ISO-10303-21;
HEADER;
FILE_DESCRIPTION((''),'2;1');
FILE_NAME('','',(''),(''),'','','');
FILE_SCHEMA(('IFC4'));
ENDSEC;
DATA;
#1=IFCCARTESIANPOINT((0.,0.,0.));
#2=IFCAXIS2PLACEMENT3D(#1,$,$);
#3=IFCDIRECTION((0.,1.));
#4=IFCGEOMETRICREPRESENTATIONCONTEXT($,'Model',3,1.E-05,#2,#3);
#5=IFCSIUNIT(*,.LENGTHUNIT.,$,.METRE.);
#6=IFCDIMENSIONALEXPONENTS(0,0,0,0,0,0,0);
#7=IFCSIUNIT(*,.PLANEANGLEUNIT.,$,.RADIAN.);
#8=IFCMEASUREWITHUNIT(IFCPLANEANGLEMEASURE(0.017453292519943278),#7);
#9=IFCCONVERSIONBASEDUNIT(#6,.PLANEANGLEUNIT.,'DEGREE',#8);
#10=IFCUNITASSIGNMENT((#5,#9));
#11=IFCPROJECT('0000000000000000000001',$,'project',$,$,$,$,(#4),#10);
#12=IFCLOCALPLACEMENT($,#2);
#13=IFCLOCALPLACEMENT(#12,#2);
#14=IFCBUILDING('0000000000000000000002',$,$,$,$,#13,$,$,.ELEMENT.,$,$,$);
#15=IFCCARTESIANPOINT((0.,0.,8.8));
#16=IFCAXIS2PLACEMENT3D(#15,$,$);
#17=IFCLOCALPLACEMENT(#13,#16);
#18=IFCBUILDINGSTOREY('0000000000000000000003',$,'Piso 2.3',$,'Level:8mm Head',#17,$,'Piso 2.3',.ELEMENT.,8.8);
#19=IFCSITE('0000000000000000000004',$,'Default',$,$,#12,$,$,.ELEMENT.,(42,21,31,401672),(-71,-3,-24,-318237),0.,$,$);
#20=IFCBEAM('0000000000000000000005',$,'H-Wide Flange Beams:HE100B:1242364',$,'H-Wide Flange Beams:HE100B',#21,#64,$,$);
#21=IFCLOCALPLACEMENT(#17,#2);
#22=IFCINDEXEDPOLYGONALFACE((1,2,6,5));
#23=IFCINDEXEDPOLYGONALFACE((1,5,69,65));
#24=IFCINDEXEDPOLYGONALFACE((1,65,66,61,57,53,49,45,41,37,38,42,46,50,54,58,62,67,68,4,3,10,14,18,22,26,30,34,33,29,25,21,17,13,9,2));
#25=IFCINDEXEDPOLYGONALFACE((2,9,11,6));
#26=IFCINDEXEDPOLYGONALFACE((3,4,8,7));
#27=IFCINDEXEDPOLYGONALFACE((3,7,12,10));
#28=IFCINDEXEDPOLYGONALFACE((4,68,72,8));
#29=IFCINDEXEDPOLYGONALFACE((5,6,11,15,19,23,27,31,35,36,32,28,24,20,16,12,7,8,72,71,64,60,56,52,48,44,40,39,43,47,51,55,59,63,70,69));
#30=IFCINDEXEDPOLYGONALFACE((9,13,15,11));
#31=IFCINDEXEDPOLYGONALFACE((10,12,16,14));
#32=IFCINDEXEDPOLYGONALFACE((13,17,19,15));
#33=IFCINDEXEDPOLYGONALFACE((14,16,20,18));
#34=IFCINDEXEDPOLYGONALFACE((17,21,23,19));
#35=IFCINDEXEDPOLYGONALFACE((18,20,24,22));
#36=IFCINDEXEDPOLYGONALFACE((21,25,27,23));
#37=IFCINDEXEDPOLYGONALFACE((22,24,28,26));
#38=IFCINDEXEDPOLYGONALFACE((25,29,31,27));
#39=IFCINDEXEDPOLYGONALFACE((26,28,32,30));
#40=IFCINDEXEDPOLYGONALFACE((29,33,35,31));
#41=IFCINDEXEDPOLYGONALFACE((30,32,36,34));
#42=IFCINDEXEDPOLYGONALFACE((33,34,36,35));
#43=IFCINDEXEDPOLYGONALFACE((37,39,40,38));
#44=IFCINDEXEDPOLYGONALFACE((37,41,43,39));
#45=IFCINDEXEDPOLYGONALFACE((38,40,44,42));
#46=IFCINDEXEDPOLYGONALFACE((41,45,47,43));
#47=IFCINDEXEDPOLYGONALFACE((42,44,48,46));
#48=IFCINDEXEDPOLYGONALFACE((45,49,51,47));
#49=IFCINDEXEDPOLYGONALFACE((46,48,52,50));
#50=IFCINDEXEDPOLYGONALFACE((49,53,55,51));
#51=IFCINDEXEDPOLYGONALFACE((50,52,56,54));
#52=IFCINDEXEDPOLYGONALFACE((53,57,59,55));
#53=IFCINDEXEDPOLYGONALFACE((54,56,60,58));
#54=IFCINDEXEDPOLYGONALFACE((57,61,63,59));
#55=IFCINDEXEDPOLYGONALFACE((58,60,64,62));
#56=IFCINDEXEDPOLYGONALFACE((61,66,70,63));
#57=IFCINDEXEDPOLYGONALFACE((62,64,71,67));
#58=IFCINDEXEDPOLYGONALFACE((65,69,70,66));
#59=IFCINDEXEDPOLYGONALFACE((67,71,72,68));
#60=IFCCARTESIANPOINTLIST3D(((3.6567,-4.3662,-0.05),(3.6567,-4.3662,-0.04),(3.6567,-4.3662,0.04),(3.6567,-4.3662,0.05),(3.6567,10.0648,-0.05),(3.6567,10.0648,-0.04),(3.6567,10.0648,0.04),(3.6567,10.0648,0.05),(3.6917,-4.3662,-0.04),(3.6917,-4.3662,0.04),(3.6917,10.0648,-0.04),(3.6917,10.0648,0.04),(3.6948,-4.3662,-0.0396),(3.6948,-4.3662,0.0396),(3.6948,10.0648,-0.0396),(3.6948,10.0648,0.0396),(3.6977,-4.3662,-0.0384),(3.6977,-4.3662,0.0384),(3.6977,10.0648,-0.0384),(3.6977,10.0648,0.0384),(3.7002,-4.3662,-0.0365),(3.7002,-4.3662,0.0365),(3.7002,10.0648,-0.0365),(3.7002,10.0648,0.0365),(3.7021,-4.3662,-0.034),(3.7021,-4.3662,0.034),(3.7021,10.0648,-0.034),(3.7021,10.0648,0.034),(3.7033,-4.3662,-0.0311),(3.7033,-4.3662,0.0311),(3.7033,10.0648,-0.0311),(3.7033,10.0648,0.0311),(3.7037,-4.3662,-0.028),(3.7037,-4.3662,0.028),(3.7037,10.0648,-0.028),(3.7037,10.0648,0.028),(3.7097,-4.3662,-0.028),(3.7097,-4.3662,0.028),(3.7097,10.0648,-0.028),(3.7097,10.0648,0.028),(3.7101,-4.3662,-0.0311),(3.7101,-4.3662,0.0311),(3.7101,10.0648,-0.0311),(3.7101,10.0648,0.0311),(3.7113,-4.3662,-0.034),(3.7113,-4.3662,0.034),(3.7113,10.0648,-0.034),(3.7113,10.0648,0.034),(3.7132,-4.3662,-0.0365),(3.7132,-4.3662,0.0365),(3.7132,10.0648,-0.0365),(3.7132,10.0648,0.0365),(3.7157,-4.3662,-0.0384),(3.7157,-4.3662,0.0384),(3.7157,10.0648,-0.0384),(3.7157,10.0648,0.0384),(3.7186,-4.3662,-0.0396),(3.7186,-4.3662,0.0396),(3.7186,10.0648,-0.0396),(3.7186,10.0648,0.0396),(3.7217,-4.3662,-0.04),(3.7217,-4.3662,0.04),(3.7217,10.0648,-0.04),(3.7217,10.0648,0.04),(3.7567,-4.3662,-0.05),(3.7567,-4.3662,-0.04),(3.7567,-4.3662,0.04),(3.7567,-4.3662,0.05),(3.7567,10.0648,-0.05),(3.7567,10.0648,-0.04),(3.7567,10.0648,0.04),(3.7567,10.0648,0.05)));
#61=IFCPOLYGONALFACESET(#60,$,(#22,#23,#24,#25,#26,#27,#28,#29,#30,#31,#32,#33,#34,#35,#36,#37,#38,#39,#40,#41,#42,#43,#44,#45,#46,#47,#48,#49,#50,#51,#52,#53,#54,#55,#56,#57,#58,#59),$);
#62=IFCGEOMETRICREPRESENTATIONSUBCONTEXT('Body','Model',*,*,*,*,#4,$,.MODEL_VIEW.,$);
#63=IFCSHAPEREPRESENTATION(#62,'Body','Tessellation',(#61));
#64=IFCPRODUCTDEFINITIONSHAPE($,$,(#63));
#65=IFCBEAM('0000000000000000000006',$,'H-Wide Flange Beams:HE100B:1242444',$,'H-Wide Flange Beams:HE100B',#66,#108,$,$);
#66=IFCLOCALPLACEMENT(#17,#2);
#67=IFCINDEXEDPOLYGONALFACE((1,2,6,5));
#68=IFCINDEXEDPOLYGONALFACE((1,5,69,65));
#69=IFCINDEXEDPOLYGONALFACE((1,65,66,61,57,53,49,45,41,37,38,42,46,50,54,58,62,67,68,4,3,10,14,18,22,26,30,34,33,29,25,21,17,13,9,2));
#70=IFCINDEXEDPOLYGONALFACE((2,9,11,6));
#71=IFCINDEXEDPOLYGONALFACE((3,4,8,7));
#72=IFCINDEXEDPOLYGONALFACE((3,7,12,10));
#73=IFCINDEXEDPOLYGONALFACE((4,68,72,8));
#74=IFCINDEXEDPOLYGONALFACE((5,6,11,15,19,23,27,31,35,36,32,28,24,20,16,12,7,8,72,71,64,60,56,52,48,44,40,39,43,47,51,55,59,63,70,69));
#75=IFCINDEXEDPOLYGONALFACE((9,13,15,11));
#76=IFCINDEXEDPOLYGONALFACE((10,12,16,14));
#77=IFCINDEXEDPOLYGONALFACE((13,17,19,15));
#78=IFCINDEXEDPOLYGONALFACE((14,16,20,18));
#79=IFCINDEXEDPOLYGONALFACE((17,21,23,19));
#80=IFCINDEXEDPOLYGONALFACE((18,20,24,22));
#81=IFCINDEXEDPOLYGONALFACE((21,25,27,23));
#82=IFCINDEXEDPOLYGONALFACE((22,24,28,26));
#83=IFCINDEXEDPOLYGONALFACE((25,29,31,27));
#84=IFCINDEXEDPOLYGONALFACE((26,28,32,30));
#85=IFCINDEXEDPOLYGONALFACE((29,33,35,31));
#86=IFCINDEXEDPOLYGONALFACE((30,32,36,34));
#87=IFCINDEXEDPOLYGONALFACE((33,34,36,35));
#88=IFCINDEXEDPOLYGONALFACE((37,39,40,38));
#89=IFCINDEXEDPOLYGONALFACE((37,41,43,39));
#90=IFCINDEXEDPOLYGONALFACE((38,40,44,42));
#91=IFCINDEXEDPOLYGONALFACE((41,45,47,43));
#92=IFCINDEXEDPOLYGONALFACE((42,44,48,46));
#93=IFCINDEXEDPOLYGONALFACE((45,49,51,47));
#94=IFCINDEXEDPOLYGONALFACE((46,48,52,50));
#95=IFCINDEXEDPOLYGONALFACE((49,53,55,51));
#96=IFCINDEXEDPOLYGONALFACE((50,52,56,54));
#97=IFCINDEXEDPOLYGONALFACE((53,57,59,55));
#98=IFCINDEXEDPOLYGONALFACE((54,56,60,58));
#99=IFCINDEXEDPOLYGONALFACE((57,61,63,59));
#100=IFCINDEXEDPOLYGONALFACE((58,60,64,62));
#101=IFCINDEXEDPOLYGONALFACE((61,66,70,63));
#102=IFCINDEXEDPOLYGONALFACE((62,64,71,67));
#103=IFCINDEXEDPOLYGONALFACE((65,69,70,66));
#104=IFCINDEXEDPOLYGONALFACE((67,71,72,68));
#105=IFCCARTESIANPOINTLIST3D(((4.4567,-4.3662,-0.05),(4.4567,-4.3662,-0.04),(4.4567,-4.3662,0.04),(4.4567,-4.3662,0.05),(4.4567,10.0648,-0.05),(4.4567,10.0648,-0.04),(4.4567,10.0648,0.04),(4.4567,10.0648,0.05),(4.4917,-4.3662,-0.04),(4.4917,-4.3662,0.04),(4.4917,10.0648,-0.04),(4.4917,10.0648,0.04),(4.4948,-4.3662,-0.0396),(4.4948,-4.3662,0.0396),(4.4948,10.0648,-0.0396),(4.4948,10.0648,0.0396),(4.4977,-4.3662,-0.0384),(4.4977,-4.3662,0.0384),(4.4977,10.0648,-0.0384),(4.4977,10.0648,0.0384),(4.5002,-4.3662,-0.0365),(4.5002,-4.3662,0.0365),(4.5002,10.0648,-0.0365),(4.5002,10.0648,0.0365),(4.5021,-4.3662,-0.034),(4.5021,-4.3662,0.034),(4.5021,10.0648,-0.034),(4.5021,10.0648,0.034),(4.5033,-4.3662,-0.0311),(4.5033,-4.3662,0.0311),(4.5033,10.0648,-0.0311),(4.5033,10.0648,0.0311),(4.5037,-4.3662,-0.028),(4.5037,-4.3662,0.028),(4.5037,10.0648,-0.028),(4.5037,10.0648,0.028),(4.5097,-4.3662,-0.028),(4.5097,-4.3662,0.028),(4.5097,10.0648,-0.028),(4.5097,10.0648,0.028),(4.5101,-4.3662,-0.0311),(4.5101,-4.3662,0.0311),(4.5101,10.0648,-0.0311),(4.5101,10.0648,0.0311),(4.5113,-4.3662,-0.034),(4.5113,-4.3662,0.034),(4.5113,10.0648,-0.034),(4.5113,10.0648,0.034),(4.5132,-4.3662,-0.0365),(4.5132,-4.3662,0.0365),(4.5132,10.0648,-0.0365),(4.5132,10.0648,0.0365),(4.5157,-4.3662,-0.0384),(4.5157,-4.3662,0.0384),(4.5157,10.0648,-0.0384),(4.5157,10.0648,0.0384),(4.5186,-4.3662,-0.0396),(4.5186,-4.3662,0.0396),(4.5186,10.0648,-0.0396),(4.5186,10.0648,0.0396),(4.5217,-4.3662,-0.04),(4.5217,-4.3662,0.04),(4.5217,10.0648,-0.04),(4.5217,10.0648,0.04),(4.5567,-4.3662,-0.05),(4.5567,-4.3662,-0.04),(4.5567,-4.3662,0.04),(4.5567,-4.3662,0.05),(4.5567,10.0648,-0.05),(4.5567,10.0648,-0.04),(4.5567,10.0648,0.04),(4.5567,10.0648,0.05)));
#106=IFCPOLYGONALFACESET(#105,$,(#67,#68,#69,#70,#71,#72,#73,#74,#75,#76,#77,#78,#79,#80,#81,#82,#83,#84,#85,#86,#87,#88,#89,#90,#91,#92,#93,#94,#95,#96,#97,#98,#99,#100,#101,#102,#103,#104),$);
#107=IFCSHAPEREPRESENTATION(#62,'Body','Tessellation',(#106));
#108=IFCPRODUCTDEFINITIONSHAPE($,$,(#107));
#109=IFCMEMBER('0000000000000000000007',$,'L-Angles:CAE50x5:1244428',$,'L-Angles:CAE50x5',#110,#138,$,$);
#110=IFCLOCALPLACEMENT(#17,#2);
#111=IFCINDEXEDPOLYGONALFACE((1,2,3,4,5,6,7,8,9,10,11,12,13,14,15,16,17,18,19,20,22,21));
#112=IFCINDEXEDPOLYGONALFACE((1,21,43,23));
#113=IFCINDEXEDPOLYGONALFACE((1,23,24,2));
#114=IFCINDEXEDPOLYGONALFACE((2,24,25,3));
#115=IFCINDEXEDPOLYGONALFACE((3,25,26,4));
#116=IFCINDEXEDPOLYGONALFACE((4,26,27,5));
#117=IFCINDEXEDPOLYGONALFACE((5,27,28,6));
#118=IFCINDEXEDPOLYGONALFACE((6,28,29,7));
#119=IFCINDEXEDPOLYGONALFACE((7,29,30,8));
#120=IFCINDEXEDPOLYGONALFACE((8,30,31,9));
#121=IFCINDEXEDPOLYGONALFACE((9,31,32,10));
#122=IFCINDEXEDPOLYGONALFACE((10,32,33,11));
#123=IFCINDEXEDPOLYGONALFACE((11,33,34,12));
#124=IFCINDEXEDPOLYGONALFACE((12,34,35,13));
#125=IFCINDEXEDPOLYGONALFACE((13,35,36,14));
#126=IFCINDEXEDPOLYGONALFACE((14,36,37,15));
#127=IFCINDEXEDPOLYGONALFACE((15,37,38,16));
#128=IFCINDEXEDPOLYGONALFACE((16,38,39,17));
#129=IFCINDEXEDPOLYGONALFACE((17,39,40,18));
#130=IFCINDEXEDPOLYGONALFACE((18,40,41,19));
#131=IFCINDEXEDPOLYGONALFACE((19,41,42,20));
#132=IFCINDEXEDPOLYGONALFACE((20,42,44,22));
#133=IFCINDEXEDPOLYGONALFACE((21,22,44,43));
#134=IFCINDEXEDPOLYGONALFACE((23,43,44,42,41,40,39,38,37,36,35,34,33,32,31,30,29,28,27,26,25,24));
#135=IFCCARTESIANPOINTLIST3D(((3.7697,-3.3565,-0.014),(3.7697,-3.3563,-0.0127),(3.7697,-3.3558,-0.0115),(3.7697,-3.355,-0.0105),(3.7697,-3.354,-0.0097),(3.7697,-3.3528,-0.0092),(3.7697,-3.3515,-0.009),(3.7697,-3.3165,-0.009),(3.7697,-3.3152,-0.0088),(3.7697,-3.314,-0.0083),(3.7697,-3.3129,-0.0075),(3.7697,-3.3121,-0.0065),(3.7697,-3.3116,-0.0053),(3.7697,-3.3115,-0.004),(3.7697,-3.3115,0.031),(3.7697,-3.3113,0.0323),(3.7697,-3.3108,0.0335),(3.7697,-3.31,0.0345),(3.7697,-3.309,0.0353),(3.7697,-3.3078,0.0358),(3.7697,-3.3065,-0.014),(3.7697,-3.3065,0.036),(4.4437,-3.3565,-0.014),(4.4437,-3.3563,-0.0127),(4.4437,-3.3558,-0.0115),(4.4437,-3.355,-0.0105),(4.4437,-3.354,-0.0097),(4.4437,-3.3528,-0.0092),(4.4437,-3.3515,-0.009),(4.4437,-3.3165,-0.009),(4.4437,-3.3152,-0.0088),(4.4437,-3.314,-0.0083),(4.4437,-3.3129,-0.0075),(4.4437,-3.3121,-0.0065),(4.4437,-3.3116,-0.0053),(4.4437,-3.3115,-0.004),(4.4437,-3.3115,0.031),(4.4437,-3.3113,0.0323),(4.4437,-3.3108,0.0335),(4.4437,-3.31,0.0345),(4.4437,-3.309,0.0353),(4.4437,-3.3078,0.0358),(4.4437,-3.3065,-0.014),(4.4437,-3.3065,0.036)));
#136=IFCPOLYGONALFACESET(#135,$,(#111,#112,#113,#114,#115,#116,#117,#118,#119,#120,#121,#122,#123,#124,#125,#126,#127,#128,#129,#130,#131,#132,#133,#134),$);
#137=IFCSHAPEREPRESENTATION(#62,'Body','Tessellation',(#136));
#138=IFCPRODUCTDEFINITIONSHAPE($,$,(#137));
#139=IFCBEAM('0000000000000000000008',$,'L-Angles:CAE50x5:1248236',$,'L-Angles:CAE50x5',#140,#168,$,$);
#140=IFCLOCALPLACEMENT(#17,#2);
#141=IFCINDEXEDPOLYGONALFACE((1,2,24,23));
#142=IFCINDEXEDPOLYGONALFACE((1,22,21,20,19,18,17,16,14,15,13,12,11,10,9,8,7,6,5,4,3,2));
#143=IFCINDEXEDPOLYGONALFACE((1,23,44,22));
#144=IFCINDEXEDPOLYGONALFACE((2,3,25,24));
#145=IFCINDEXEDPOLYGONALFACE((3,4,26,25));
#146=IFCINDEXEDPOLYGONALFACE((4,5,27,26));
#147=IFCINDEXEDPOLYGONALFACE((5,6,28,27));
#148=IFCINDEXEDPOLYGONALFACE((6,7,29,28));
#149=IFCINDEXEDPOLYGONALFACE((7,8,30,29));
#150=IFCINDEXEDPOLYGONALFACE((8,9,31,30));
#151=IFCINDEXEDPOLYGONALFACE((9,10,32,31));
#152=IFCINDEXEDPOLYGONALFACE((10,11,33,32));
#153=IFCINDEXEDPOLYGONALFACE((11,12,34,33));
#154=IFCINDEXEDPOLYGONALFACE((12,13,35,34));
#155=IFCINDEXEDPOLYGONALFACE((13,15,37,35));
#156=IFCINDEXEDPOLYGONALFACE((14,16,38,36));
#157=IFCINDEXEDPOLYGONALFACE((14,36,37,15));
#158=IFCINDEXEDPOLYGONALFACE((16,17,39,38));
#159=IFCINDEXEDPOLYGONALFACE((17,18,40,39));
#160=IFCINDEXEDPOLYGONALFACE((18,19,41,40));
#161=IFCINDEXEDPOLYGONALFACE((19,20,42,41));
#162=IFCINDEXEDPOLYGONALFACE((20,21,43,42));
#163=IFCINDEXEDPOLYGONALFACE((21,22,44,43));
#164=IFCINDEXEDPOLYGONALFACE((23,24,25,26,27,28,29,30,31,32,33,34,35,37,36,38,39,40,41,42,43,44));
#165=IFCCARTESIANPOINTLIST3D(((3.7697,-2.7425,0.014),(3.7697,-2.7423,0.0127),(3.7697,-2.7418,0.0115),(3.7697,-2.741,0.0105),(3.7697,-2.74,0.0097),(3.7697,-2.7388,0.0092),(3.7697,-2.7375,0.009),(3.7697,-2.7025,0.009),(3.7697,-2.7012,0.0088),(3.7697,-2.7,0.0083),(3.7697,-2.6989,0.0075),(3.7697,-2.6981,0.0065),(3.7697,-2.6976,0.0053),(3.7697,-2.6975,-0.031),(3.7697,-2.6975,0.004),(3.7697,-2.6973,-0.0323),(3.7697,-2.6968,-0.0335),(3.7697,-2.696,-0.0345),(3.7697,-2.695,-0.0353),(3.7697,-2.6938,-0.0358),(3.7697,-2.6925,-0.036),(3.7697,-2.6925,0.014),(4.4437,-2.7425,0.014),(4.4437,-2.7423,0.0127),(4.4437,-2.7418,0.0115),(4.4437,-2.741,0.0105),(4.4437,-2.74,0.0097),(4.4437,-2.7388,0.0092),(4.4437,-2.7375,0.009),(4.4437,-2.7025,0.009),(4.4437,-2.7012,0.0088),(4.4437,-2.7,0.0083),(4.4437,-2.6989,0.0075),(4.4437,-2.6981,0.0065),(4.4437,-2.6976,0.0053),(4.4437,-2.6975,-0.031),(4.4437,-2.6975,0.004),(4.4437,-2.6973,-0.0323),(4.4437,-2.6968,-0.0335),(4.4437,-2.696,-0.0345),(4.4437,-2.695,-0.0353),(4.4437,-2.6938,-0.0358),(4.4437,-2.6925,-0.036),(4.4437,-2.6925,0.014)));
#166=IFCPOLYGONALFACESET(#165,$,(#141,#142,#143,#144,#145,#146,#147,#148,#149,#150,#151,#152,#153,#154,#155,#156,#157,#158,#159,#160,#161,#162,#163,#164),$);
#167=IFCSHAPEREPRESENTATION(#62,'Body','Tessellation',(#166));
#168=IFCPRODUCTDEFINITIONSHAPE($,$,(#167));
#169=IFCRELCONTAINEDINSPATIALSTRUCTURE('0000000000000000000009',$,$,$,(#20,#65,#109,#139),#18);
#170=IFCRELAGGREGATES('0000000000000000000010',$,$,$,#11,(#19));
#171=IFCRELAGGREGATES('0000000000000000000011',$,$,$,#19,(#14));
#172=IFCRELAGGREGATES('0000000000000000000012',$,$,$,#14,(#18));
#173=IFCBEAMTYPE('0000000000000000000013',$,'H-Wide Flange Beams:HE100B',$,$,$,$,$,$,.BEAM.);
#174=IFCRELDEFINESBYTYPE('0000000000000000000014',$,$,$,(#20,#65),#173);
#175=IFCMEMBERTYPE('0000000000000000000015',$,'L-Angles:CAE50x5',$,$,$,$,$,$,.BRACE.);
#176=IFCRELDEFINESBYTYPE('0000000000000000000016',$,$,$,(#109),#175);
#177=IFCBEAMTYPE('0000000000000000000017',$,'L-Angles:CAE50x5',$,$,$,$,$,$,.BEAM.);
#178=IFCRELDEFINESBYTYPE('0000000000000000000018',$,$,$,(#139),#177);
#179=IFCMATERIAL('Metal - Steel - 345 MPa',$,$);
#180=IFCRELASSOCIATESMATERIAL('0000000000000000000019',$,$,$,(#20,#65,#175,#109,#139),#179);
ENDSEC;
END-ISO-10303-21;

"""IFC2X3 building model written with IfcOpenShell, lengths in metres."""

from ifc_helpers import new_model, entity, si_unit, converted_unit, direction, frame, frame_2d, origin, place, context, subcontext, project, spatial, polyline, circle_curve, parameter, trimmed, segment, composite_curve, i_section, outline, extrude, source, transform, mapped, material, type_object, type_shapes, element, save


model = new_model("IFC2X3")

# Units and contexts
model_context = context("Model", 3, precision=1e-05, world=origin(), true_north=direction((0.0, 1.0)))
body_context = subcontext(model_context, "Body", "Model", "MODEL_VIEW")
ifc_project = project(units=[si_unit("LENGTHUNIT", "METRE"), converted_unit("PLANEANGLEUNIT", "DEGREE", entity("IfcPlaneAngleMeasure", 0.017453292519943278), si_unit("PLANEANGLEUNIT", "RADIAN"), dimensions=[0, 0, 0, 0, 0, 0, 0])], contexts=[model_context])

# Site, building, storey
site_placement = place(None, origin())
site = spatial("IfcSite", under=ifc_project, at=site_placement, Name="Default", CompositionType="ELEMENT", RefLatitude=(42, 21, 31, 401672), RefLongitude=(-71, -3, -24, -318237), RefElevation=0.0)
building_placement = place(site_placement, origin())
building = spatial("IfcBuilding", under=site, at=building_placement, CompositionType="ELEMENT")
storey_placement = place(building_placement, frame((0.0, 0.0, 8.8)))
storey = spatial("IfcBuildingStorey", under=building, at=storey_placement, Name="Piso 2.3", ObjectType="Level:8mm Head", LongName="Piso 2.3", CompositionType="ELEMENT", Elevation=8.8)

# Beams
ifc_material_1 = material(Name="Metal - Steel - 345 MPa")
beam_type_1 = type_object("IfcBeamType", Name="H-Wide Flange Beams:HE100B", PredefinedType="BEAM")
beam_1_placement = place(storey_placement, frame((3.7067, -4.3265, 0.0), z_axis=(0.0, 0.0, 1.0), x_axis=(0.0, 1.0, 0.0)))
element("IfcBeam", 1, at=beam_1_placement, inside=storey, type_object=beam_type_1, material=ifc_material_1, Name="H-Wide Flange Beams:HE100B:1242364", ObjectType="H-Wide Flange Beams:HE100B", context=body_context, shape_type="SweptSolid", body=[
    extrude(i_section(OverallWidth=0.1, OverallDepth=0.1, WebThickness=0.006, FlangeThickness=0.01, FilletRadius=0.012, at=frame_2d((0.0, 0.0), x_axis=(0.0, 1.0))), frame((-0.0397, 0.0, 0.0), z_axis=(1.0, 0.0, 0.0), x_axis=(0.0, 0.0, -1.0)), (0.0, 0.0, 1.0), 14.431),
])
beam_2_placement = place(storey_placement, frame((4.5067, -3.7965, 0.0), z_axis=(0.0, 0.0, 1.0), x_axis=(0.0, 1.0, 0.0)))
element("IfcBeam", 2, at=beam_2_placement, inside=storey, type_object=beam_type_1, material=ifc_material_1, Name="H-Wide Flange Beams:HE100B:1242444", ObjectType="H-Wide Flange Beams:HE100B", context=body_context, shape_type="SweptSolid", body=[
    extrude(i_section(OverallWidth=0.1, OverallDepth=0.1, WebThickness=0.006, FlangeThickness=0.01, FilletRadius=0.012, at=frame_2d((0.0, 0.0), x_axis=(0.0, 1.0))), frame((-0.5697, 0.0, 0.0), z_axis=(1.0, 0.0, 0.0), x_axis=(0.0, 0.0, -1.0)), (0.0, 0.0, 1.0), 14.431),
])

# Member
member_type_1 = type_object("IfcMemberType", Name="L-Angles:CAE50x5", PredefinedType="BRACE", material=ifc_material_1)
shared_shape_1 = source(origin(), body_context, "Body", "SweptSolid", [
    extrude(outline(composite_curve([segment(polyline([(-0.0164, -0.0164), (0.0336, -0.0164)]), True, "CONTINUOUS"), segment(trimmed(circle_curve(frame_2d((0.0286, -0.0164), x_axis=(1.0, 0.0)), 0.005), [parameter(0.0)], [parameter(90.0)], True, "PARAMETER"), True, "CONTINUOUS"), segment(polyline([(0.0286, -0.0114), (-0.0064, -0.0114)]), True, "CONTINUOUS"), segment(trimmed(circle_curve(frame_2d((-0.0064, -0.0064), x_axis=(1.0, 0.0)), 0.005), [parameter(180.0)], [parameter(270.0)], True, "PARAMETER"), False, "CONTINUOUS"), segment(polyline([(-0.0114, -0.0064), (-0.0114, 0.0286)]), True, "CONTINUOUS"), segment(trimmed(circle_curve(frame_2d((-0.0164, 0.0286), x_axis=(1.0, 0.0)), 0.005), [parameter(0.0)], [parameter(90.0)], True, "PARAMETER"), True, "CONTINUOUS"), segment(polyline([(-0.0164, 0.0336), (-0.0164, -0.0164)]), True, "CONTINUOUS")], self_intersect=False)), frame((-0.337, -0.0024, -0.0024), z_axis=(1.0, 0.0, 0.0), x_axis=(0.0, -1.0, 0.0)), (0.0, 0.0, 1.0), 0.674),
])
type_shapes(member_type_1, [shared_shape_1])
member_1_placement = place(storey_placement, frame((4.1067, -3.3205, 0.0), z_axis=(0.0, 1.0, 0.0), x_axis=(1.0, 0.0, 0.0)))
element("IfcMember", 3, at=member_1_placement, inside=storey, type_object=member_type_1, material=ifc_material_1, Name="L-Angles:CAE50x5:1244428", ObjectType="L-Angles:CAE50x5", context=body_context, shape_type="MappedRepresentation", body=[
    mapped(shared_shape_1, transform((0.0, 0.0, 0.0), scale=1.0)),
])

# Beam
beam_type_2 = type_object("IfcBeamType", Name="L-Angles:CAE50x5", PredefinedType="BEAM")
beam_3_placement = place(storey_placement, frame((3.7067, -2.7065, 0.0)))
element("IfcBeam", 4, at=beam_3_placement, inside=storey, type_object=beam_type_2, material=ifc_material_1, Name="L-Angles:CAE50x5:1248236", ObjectType="L-Angles:CAE50x5", context=body_context, shape_type="SweptSolid", body=[
    extrude(outline(composite_curve([segment(polyline([(-0.0336, -0.0164), (0.0164, -0.0164)]), True, "CONTINUOUS"), segment(polyline([(0.0164, -0.0164), (0.0164, 0.0336)]), True, "CONTINUOUS"), segment(trimmed(circle_curve(frame_2d((0.0164, 0.0286), x_axis=(0.0, 1.0)), 0.005), [parameter(0.0)], [parameter(90.0)], True, "PARAMETER"), True, "CONTINUOUS"), segment(polyline([(0.0114, 0.0286), (0.0114, -0.0064)]), True, "CONTINUOUS"), segment(trimmed(circle_curve(frame_2d((0.0064, -0.0064), x_axis=(1.0, 0.0)), 0.005), [parameter(270.0)], [parameter(0.0)], True, "PARAMETER"), False, "CONTINUOUS"), segment(polyline([(0.0064, -0.0114), (-0.0286, -0.0114)]), True, "CONTINUOUS"), segment(trimmed(circle_curve(frame_2d((-0.0286, -0.0164), x_axis=(0.0, 1.0)), 0.005), [parameter(0.0)], [parameter(90.0)], True, "PARAMETER"), True, "CONTINUOUS")], self_intersect=False)), frame((0.063, -0.0024, -0.0024), z_axis=(1.0, 0.0, 0.0), x_axis=(0.0, 0.0, 1.0)), (0.0, 0.0, 1.0), 0.674),
])

save(model, "model.ifc")
